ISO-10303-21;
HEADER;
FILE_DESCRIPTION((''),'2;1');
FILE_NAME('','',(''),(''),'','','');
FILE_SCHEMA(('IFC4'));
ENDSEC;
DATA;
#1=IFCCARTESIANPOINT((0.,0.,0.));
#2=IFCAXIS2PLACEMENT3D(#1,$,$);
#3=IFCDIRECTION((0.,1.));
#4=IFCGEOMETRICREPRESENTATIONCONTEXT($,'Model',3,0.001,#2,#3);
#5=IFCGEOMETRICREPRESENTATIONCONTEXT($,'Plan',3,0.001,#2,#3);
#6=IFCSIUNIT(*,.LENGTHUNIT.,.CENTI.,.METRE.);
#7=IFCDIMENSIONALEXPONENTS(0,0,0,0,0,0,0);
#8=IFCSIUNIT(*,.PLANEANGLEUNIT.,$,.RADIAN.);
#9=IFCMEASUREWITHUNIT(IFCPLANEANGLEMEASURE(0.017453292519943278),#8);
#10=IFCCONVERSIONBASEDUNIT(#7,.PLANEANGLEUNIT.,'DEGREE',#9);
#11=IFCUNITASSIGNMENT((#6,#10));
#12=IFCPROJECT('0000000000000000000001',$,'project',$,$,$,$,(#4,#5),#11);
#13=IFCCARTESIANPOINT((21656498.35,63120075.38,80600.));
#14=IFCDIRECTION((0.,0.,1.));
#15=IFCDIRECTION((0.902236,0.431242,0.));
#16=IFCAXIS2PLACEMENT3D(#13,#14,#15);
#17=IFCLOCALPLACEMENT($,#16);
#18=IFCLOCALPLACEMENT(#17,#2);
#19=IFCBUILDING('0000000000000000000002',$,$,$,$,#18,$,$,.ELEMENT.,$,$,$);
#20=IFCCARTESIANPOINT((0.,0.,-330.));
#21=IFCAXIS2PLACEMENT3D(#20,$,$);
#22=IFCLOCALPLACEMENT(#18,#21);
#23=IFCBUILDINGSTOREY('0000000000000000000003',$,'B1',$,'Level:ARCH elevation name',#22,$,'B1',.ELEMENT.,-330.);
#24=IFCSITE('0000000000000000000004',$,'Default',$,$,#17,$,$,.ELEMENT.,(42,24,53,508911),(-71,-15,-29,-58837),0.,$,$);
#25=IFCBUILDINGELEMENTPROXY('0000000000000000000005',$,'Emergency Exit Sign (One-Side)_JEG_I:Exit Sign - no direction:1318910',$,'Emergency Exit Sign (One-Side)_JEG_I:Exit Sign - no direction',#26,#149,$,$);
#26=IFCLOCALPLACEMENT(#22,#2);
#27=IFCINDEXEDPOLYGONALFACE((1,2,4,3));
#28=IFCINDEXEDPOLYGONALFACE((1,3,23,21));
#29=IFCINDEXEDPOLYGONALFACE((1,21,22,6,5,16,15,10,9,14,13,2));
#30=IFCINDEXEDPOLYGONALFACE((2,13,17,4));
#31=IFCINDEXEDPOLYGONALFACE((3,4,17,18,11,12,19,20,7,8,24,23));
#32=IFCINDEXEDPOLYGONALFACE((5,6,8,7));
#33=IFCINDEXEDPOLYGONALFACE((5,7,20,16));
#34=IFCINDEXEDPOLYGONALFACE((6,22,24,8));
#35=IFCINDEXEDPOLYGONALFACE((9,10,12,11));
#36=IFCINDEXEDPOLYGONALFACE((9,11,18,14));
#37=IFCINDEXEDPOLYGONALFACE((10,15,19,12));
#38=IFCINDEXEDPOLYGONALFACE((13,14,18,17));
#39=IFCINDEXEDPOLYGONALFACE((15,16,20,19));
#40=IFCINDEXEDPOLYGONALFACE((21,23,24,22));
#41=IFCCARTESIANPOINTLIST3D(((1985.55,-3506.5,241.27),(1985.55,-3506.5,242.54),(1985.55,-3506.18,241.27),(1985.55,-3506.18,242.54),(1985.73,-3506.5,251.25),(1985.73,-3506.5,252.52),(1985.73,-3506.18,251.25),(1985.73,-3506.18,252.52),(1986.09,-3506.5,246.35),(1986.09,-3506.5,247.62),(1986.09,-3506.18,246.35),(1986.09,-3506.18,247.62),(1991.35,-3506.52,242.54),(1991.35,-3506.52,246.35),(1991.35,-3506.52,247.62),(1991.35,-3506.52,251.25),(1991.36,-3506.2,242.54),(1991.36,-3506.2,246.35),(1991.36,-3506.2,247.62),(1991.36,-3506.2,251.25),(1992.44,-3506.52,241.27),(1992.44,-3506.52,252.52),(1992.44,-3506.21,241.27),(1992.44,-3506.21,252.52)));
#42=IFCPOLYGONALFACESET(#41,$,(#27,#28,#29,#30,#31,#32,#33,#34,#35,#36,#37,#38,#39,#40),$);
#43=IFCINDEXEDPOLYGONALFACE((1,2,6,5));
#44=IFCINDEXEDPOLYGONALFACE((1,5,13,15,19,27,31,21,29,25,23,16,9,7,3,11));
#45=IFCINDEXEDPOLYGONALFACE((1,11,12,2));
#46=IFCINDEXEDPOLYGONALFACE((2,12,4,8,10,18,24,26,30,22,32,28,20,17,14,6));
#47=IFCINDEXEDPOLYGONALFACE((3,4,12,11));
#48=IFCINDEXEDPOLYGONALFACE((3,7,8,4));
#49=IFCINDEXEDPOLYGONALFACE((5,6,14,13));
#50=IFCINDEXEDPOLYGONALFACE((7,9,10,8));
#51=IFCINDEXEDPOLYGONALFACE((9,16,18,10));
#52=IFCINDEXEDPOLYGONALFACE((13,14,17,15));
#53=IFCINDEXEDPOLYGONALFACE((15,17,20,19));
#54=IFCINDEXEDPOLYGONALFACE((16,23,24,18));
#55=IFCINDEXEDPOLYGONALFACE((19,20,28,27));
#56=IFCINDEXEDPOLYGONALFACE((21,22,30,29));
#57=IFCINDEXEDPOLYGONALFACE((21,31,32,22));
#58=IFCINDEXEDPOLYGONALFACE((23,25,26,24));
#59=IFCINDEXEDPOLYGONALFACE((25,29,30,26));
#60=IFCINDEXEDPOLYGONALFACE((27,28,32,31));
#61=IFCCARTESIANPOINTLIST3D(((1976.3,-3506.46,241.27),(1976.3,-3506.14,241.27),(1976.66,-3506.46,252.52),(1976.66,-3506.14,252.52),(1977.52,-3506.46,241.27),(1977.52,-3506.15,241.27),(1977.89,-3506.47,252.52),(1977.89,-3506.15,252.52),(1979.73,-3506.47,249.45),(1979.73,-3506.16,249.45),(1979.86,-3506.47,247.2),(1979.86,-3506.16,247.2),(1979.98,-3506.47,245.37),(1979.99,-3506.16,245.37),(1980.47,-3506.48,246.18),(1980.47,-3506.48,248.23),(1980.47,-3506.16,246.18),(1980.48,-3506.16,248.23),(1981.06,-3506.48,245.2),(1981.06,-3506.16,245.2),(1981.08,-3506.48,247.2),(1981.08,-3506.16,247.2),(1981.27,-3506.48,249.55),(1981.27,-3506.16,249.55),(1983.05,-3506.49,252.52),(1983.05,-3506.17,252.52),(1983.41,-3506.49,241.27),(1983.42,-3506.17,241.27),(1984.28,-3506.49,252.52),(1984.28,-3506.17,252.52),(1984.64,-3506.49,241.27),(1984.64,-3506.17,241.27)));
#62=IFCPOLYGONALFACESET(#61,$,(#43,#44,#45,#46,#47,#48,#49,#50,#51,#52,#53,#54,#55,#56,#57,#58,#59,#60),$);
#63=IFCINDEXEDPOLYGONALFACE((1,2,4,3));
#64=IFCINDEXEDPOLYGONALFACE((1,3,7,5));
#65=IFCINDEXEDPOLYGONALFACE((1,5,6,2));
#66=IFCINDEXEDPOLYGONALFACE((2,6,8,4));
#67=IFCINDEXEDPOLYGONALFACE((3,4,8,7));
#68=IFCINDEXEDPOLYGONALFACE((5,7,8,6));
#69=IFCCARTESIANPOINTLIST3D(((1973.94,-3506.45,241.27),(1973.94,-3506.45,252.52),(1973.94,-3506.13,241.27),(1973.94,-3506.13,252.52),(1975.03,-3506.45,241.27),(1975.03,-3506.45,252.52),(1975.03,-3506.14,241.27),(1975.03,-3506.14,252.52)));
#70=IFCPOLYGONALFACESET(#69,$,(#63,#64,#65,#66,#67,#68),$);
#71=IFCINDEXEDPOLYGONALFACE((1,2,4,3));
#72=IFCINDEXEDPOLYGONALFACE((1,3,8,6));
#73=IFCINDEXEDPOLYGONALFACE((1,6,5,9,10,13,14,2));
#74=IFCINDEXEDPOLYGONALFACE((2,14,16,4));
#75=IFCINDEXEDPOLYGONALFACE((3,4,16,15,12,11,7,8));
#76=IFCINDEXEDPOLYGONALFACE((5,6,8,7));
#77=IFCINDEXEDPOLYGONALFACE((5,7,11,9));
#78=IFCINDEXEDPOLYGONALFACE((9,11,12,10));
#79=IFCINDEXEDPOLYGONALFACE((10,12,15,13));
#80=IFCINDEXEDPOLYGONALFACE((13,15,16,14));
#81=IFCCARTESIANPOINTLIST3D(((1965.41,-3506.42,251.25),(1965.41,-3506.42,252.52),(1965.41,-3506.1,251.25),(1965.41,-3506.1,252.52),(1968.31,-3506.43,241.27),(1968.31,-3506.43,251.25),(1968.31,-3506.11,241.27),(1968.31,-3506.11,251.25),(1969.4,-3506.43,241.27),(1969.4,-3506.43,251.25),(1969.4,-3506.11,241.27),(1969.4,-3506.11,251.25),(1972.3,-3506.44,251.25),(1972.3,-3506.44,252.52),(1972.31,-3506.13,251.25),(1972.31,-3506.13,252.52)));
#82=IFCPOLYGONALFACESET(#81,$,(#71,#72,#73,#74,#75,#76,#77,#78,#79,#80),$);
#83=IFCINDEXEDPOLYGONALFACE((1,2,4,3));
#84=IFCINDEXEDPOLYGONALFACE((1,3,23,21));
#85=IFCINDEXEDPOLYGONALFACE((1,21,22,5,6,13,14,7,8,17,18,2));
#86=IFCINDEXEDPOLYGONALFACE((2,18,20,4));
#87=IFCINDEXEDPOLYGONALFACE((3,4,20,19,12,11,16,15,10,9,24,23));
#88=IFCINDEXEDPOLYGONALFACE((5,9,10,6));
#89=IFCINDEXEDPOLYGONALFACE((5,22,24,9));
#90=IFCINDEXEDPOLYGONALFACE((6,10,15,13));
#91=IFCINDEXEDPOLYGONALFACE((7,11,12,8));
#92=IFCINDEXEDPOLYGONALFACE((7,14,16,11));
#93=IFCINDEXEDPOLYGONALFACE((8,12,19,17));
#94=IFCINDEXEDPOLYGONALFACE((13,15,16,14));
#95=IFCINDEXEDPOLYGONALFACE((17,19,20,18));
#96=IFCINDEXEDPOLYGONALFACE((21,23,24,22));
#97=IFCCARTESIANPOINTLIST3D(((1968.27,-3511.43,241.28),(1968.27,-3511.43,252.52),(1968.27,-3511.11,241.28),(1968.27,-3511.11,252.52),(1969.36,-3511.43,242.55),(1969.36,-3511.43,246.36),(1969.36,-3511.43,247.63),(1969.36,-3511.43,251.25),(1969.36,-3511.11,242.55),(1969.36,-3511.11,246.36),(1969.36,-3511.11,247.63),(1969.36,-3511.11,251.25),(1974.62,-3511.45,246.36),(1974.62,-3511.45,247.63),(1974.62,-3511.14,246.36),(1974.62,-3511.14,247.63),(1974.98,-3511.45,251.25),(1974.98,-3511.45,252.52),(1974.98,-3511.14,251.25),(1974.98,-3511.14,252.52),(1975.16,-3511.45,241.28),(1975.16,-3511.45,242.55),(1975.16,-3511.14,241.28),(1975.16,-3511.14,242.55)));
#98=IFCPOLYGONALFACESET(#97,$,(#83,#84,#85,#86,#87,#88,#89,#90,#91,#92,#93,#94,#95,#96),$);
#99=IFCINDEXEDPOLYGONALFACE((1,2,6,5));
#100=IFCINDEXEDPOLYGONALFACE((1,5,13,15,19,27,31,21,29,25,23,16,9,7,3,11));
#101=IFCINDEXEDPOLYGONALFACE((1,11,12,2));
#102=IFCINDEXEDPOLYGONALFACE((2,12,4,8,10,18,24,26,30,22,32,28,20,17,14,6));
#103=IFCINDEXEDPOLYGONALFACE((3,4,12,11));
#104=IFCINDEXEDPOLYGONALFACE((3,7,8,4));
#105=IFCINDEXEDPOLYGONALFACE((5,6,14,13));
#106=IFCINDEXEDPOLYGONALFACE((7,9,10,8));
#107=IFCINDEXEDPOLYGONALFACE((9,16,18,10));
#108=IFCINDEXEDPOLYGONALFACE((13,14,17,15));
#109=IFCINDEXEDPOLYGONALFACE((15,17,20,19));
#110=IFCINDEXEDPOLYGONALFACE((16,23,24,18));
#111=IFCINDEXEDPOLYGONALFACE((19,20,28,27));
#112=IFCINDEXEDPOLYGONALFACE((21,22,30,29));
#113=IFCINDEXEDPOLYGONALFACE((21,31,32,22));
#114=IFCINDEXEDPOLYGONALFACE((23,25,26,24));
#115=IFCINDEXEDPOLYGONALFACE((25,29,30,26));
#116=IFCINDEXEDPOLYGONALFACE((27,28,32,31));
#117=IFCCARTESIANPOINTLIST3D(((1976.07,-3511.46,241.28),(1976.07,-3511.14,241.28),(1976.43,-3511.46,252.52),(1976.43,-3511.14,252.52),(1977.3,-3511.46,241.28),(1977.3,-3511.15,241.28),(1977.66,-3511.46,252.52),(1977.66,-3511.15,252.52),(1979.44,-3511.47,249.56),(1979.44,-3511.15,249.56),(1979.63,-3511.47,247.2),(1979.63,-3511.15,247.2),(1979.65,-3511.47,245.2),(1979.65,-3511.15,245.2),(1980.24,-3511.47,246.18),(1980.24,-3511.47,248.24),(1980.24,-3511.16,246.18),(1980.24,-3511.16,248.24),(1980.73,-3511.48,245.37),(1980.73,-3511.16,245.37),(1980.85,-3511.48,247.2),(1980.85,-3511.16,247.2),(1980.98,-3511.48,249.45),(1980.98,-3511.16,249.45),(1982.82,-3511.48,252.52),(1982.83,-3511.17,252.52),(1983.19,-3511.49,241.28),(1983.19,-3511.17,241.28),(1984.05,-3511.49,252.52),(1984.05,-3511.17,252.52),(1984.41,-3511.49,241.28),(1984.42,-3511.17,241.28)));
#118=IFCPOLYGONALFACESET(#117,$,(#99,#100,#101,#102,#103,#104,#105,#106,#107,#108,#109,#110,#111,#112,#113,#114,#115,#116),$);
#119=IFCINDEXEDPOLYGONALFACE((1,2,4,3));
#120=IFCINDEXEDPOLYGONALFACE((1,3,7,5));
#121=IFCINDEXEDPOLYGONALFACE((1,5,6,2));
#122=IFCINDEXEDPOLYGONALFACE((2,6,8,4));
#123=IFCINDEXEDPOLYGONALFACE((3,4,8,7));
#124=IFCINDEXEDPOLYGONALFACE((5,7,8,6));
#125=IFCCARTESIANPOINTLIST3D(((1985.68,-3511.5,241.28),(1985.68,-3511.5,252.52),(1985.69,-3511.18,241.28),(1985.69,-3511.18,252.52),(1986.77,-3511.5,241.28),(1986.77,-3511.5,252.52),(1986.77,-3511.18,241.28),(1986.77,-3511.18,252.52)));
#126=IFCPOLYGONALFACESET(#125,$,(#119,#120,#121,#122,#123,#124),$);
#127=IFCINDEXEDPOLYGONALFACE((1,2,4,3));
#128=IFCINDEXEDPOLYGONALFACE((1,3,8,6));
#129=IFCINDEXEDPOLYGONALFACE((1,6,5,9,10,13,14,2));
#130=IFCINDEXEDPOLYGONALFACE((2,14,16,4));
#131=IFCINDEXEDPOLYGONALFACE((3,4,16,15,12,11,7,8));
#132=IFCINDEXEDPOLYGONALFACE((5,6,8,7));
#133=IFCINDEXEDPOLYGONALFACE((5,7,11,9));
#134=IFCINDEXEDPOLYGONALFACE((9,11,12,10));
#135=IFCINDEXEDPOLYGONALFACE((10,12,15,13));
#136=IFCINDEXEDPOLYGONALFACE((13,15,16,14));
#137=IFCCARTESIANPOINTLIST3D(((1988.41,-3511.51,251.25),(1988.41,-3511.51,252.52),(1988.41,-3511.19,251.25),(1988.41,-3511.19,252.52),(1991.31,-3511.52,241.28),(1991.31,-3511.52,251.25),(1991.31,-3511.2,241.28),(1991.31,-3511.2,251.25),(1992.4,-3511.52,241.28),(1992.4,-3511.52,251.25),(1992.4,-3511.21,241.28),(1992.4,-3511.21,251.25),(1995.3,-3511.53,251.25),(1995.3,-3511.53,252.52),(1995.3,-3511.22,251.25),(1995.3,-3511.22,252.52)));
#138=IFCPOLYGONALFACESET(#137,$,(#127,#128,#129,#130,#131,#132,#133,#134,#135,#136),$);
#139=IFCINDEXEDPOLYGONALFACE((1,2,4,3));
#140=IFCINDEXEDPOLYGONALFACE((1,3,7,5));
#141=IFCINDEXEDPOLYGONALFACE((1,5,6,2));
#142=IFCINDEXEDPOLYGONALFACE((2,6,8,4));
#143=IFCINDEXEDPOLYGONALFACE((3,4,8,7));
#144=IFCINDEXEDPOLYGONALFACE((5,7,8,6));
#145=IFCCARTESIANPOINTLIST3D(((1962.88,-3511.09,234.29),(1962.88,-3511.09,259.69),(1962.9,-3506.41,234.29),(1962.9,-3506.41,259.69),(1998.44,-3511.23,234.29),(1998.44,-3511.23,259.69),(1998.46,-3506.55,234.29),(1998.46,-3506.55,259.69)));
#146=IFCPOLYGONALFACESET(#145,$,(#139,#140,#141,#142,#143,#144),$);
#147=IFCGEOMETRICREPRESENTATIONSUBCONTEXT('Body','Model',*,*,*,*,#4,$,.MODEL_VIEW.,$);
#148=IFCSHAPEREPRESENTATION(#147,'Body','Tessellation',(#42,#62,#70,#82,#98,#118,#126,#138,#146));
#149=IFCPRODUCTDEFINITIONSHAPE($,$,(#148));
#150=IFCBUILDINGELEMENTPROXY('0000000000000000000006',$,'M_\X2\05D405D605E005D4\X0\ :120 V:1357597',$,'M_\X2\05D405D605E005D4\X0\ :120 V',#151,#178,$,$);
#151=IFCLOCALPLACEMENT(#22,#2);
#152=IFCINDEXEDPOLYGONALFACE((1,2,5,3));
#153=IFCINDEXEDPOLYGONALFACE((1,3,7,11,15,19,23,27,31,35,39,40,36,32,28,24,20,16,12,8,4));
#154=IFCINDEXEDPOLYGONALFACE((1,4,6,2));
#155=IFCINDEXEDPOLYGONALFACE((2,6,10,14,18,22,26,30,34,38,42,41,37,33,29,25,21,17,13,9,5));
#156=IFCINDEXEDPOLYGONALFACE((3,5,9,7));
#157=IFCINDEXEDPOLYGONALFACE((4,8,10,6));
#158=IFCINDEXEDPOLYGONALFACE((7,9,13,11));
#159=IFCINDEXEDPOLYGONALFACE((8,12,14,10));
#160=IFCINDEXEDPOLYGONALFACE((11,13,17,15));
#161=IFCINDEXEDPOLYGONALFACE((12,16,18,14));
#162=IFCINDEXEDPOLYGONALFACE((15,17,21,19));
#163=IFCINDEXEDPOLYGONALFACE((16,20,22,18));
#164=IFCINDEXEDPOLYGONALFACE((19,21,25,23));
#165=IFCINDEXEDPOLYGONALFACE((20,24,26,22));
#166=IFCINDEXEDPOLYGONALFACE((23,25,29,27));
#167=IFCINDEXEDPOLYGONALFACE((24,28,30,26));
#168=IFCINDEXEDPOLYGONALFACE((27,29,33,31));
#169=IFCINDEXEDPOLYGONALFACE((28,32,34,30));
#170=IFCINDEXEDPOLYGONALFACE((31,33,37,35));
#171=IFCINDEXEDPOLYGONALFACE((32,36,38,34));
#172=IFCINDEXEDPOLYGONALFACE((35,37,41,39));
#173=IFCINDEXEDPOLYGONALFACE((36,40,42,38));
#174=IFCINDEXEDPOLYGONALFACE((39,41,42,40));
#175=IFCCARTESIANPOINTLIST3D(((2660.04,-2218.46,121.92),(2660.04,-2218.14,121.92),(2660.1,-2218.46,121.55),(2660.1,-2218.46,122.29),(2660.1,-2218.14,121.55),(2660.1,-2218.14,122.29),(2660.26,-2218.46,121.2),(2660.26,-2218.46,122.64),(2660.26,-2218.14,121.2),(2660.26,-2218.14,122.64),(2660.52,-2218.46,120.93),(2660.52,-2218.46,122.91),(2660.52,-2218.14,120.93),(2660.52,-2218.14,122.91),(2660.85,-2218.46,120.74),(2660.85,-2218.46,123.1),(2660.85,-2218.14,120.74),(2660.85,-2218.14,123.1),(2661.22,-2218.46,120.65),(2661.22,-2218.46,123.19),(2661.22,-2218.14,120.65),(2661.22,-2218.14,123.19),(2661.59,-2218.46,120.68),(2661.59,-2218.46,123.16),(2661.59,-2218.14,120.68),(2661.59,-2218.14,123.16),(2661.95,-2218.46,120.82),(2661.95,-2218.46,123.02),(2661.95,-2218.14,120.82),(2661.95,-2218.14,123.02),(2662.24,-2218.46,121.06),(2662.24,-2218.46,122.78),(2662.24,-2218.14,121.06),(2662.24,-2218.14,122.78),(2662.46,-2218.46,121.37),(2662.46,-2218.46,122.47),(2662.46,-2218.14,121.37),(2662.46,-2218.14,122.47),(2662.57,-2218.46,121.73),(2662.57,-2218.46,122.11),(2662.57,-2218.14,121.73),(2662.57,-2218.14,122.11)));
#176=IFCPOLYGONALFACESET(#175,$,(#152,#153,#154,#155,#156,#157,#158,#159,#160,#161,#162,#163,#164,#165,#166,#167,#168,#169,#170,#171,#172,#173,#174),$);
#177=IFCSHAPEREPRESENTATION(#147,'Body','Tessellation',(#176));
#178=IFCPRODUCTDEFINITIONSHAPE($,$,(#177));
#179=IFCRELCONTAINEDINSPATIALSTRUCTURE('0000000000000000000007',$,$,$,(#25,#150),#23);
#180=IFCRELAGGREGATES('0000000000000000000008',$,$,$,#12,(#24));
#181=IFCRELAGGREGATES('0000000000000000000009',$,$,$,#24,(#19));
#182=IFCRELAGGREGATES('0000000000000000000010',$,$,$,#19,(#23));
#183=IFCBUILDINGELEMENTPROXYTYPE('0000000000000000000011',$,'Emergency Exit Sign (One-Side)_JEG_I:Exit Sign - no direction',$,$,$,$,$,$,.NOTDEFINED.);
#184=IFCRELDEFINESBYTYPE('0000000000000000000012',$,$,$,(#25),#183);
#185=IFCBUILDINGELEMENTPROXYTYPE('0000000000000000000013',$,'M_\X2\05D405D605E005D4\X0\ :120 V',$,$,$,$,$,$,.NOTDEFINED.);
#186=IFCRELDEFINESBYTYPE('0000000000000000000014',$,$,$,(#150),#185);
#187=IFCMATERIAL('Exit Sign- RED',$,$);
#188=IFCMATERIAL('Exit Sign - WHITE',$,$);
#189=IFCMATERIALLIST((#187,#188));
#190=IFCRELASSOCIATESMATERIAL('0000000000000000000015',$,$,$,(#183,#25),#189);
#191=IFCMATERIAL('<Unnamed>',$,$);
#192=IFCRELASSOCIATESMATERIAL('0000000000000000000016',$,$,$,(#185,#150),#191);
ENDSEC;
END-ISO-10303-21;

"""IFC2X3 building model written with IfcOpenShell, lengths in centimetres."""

from ifc_helpers import new_model, entity, si_unit, converted_unit, direction, frame, frame_2d, origin, origin_2d_with_axis, place, context, subcontext, project, spatial, polyline, rectangle, circle, outline, extrude, source, transform, mapped, material, material_list, type_object, type_shapes, element, save


model = new_model("IFC2X3")

# Units and contexts
model_context = context("Model", 3, precision=0.001, world=origin(), true_north=direction((0.0, 1.0)))
plan_context = context("Plan", 3, precision=0.001, world=origin(), true_north=direction((0.0, 1.0)))
body_context = subcontext(model_context, "Body", "Model", "MODEL_VIEW")
ifc_project = project(units=[si_unit("LENGTHUNIT", "METRE", prefix="CENTI"), converted_unit("PLANEANGLEUNIT", "DEGREE", entity("IfcPlaneAngleMeasure", 0.017453292519943278), si_unit("PLANEANGLEUNIT", "RADIAN"), dimensions=[0, 0, 0, 0, 0, 0, 0])], contexts=[model_context, plan_context])

# Site, building, storey
site_placement = place(None, frame((21656498.35, 63120075.38, 80600.0), z_axis=(0.0, 0.0, 1.0), x_axis=(0.902236, 0.431242, 0.0)))
site = spatial("IfcSite", under=ifc_project, at=site_placement, Name="Default", CompositionType="ELEMENT", RefLatitude=(42, 24, 53, 508911), RefLongitude=(-71, -15, -29, -58837), RefElevation=0.0)
building_placement = place(site_placement, origin())
building = spatial("IfcBuilding", under=site, at=building_placement, CompositionType="ELEMENT")
storey_placement = place(building_placement, frame((0.0, 0.0, -330.0)))
storey = spatial("IfcBuildingStorey", under=building, at=storey_placement, Name="B1", ObjectType="Level:ARCH elevation name", LongName="B1", CompositionType="ELEMENT", Elevation=-330.0)

# Shared definitions
ifc_material_1 = material(Name="Exit Sign - WHITE")
ifc_material_2 = material(Name="Exit Sign- RED")

# Building element proxies
ifc_material_3 = material(Name="<Unnamed>")
ifc_material_list_1 = material_list([ifc_material_2, ifc_material_1])
building_element_proxy_type_1 = type_object("IfcBuildingElementProxyType", Name="Emergency Exit Sign (One-Side)_JEG_I:Exit Sign - no direction", PredefinedType="NOTDEFINED", material=ifc_material_list_1)
shared_shape_1 = source(origin(), body_context, "Body", "SweptSolid", [
    extrude(outline(polyline([(-5.65, -3.69), (5.59, -3.69), (5.59, 3.02), (4.32, 3.02), (4.32, -2.6), (0.7, -2.6), (0.7, 2.66), (-0.57, 2.66), (-0.57, -2.6), (-4.38, -2.6), (-4.38, 3.21), (-5.65, 3.21), (-5.65, -3.69)])), frame((-8.08, -5.22, 12.64), z_axis=(0.0, 1.0, 0.0), x_axis=(0.0, 0.0, 1.0)), (0.0, 0.0, 1.0), 0.32),
    extrude(outline(polyline([(-7.14, 0.57), (-6.5, -0.49), (-1.93, -0.48), (-0.78, -0.48), (-1.23, -1.32), (-3.47, -5.53), (-2.84, -6.59), (0.41, -0.48), (6.62, -0.48), (5.99, 0.57), (2.4, 0.57), (0.98, 0.58), (1.7, 1.94), (3.32, 5.0), (2.69, 6.05), (-0.22, 0.57), (-7.14, 0.57)])), frame((0.2, -5.22, 12.81), z_axis=(0.0, -1.0, 0.0), x_axis=(0.515099, 0.0, 0.857131)), (0.0, 0.0, -1.0), 0.32),
    extrude(rectangle(XDim=0.32, YDim=1.09, at=frame_2d((0.0, 0.0), x_axis=(1.0, 0.0))), frame((6.19, -5.06, 6.99), z_axis=(0.0, 0.0, 1.0), x_axis=(0.0, 1.0, 0.0)), (0.0, 0.0, 1.0), 11.25),
    extrude(outline(polyline([(-7.8, 0.54), (-7.8, -0.54), (2.18, -0.54), (2.18, -3.45), (3.45, -3.45), (3.45, 3.45), (2.18, 3.45), (2.18, 0.54), (-7.8, 0.54)])), frame((11.82, -5.22, 14.79), z_axis=(0.0, -1.0, 0.0), x_axis=(0.0, 0.0, 1.0)), (0.0, 0.0, -1.0), 0.32),
    extrude(outline(polyline([(-3.69, -5.65), (3.21, -5.65), (3.21, -4.38), (-2.6, -4.38), (-2.6, -0.57), (2.66, -0.57), (2.66, 0.7), (-2.6, 0.7), (-2.6, 4.32), (3.02, 4.32), (3.02, 5.59), (-3.69, 5.59), (-3.69, -5.65)])), frame((8.7, -0.22, 12.65), z_axis=(0.0, 1.0, 0.0), x_axis=(-1.0, 0.0, 0.0)), (0.0, 0.0, 1.0), 0.32),
    extrude(outline(polyline([(-4.16, -5.82), (-2.93, -5.82), (-0.58, -1.9), (0.01, -0.92), (0.5, -1.73), (2.96, -5.82), (4.18, -5.82), (0.62, 0.1), (3.82, 5.42), (2.59, 5.42), (0.75, 2.35), (0.01, 1.14), (-0.79, 2.46), (-2.57, 5.42), (-3.8, 5.42), (-0.6, 0.1), (-4.16, -5.82)])), frame((0.43, -0.22, 12.82), z_axis=(0.0, 1.0, 0.0), x_axis=(-1.0, 0.0, 0.0)), (0.0, 0.0, 1.0), 0.32),
    extrude(rectangle(XDim=0.32, YDim=1.09, at=origin_2d_with_axis()), frame((-5.57, -0.06, 6.99), z_axis=(0.0, 0.0, 1.0), x_axis=(0.0, -1.0, 0.0)), (0.0, 0.0, 1.0), 11.25),
    extrude(outline(polyline([(-0.54, -7.8), (0.54, -7.8), (0.54, 2.18), (3.45, 2.18), (3.45, 3.45), (-3.45, 3.45), (-3.45, 2.18), (-0.54, 2.18), (-0.54, -7.8)])), frame((-11.2, -0.22, 14.79), z_axis=(0.0, 1.0, 0.0), x_axis=(-1.0, 0.0, 0.0)), (0.0, 0.0, 1.0), 0.32),
    extrude(rectangle(XDim=4.68, YDim=35.56, at=origin_2d_with_axis()), frame((0.0, -2.56, 0.01), z_axis=(0.0, 0.0, 1.0), x_axis=(0.0, 1.0, 0.0)), (0.0, 0.0, 1.0), 25.4),
])
type_shapes(building_element_proxy_type_1, [shared_shape_1])
for number, where, z_axis, x_axis, name in (
    (1, (1980.66, -3511.38, 234.28), (0.0, 0.0, 1.0), (-0.999992, 0.00394, 0.0), "Emergency Exit Sign (One-Side)_JEG_I:Exit Sign - no direction:1318910"),
):
    element("IfcBuildingElementProxy", number, at=place(storey_placement, frame(where, z_axis=z_axis, x_axis=x_axis)), inside=storey, type_object=building_element_proxy_type_1, material=ifc_material_list_1, Name=name, ObjectType="Emergency Exit Sign (One-Side)_JEG_I:Exit Sign - no direction", context=body_context, shape_type="MappedRepresentation", body=[
        mapped(shared_shape_1, transform((0.0, 0.0, 0.0), scale=1.0)),
    ])
building_element_proxy_type_2 = type_object("IfcBuildingElementProxyType", Name="M_הזנה :120 V", PredefinedType="NOTDEFINED", material=ifc_material_3)
shared_shape_2 = source(origin(), body_context, "Body", "SweptSolid", [
    extrude(circle(Radius=1.27, at=frame_2d((0.0, 0.0), x_axis=(1.0, 0.0))), origin(), (0.0, 0.0, 1.0), 0.32),
])
type_shapes(building_element_proxy_type_2, [shared_shape_2])
for number, where, z_axis, x_axis, name in (
    (2, (2661.31, -2218.46, 121.92), (0.0, 1.0, 0.0), (-1.0, 0.0, 0.0), "M_הזנה :120 V:1357597"),
):
    element("IfcBuildingElementProxy", number, at=place(storey_placement, frame(where, z_axis=z_axis, x_axis=x_axis)), inside=storey, type_object=building_element_proxy_type_2, material=ifc_material_3, Name=name, ObjectType="M_הזנה :120 V", context=body_context, shape_type="MappedRepresentation", body=[
        mapped(shared_shape_2, transform((0.0, 0.0, 0.0), scale=1.0)),
    ])

save(model, "model.ifc")
